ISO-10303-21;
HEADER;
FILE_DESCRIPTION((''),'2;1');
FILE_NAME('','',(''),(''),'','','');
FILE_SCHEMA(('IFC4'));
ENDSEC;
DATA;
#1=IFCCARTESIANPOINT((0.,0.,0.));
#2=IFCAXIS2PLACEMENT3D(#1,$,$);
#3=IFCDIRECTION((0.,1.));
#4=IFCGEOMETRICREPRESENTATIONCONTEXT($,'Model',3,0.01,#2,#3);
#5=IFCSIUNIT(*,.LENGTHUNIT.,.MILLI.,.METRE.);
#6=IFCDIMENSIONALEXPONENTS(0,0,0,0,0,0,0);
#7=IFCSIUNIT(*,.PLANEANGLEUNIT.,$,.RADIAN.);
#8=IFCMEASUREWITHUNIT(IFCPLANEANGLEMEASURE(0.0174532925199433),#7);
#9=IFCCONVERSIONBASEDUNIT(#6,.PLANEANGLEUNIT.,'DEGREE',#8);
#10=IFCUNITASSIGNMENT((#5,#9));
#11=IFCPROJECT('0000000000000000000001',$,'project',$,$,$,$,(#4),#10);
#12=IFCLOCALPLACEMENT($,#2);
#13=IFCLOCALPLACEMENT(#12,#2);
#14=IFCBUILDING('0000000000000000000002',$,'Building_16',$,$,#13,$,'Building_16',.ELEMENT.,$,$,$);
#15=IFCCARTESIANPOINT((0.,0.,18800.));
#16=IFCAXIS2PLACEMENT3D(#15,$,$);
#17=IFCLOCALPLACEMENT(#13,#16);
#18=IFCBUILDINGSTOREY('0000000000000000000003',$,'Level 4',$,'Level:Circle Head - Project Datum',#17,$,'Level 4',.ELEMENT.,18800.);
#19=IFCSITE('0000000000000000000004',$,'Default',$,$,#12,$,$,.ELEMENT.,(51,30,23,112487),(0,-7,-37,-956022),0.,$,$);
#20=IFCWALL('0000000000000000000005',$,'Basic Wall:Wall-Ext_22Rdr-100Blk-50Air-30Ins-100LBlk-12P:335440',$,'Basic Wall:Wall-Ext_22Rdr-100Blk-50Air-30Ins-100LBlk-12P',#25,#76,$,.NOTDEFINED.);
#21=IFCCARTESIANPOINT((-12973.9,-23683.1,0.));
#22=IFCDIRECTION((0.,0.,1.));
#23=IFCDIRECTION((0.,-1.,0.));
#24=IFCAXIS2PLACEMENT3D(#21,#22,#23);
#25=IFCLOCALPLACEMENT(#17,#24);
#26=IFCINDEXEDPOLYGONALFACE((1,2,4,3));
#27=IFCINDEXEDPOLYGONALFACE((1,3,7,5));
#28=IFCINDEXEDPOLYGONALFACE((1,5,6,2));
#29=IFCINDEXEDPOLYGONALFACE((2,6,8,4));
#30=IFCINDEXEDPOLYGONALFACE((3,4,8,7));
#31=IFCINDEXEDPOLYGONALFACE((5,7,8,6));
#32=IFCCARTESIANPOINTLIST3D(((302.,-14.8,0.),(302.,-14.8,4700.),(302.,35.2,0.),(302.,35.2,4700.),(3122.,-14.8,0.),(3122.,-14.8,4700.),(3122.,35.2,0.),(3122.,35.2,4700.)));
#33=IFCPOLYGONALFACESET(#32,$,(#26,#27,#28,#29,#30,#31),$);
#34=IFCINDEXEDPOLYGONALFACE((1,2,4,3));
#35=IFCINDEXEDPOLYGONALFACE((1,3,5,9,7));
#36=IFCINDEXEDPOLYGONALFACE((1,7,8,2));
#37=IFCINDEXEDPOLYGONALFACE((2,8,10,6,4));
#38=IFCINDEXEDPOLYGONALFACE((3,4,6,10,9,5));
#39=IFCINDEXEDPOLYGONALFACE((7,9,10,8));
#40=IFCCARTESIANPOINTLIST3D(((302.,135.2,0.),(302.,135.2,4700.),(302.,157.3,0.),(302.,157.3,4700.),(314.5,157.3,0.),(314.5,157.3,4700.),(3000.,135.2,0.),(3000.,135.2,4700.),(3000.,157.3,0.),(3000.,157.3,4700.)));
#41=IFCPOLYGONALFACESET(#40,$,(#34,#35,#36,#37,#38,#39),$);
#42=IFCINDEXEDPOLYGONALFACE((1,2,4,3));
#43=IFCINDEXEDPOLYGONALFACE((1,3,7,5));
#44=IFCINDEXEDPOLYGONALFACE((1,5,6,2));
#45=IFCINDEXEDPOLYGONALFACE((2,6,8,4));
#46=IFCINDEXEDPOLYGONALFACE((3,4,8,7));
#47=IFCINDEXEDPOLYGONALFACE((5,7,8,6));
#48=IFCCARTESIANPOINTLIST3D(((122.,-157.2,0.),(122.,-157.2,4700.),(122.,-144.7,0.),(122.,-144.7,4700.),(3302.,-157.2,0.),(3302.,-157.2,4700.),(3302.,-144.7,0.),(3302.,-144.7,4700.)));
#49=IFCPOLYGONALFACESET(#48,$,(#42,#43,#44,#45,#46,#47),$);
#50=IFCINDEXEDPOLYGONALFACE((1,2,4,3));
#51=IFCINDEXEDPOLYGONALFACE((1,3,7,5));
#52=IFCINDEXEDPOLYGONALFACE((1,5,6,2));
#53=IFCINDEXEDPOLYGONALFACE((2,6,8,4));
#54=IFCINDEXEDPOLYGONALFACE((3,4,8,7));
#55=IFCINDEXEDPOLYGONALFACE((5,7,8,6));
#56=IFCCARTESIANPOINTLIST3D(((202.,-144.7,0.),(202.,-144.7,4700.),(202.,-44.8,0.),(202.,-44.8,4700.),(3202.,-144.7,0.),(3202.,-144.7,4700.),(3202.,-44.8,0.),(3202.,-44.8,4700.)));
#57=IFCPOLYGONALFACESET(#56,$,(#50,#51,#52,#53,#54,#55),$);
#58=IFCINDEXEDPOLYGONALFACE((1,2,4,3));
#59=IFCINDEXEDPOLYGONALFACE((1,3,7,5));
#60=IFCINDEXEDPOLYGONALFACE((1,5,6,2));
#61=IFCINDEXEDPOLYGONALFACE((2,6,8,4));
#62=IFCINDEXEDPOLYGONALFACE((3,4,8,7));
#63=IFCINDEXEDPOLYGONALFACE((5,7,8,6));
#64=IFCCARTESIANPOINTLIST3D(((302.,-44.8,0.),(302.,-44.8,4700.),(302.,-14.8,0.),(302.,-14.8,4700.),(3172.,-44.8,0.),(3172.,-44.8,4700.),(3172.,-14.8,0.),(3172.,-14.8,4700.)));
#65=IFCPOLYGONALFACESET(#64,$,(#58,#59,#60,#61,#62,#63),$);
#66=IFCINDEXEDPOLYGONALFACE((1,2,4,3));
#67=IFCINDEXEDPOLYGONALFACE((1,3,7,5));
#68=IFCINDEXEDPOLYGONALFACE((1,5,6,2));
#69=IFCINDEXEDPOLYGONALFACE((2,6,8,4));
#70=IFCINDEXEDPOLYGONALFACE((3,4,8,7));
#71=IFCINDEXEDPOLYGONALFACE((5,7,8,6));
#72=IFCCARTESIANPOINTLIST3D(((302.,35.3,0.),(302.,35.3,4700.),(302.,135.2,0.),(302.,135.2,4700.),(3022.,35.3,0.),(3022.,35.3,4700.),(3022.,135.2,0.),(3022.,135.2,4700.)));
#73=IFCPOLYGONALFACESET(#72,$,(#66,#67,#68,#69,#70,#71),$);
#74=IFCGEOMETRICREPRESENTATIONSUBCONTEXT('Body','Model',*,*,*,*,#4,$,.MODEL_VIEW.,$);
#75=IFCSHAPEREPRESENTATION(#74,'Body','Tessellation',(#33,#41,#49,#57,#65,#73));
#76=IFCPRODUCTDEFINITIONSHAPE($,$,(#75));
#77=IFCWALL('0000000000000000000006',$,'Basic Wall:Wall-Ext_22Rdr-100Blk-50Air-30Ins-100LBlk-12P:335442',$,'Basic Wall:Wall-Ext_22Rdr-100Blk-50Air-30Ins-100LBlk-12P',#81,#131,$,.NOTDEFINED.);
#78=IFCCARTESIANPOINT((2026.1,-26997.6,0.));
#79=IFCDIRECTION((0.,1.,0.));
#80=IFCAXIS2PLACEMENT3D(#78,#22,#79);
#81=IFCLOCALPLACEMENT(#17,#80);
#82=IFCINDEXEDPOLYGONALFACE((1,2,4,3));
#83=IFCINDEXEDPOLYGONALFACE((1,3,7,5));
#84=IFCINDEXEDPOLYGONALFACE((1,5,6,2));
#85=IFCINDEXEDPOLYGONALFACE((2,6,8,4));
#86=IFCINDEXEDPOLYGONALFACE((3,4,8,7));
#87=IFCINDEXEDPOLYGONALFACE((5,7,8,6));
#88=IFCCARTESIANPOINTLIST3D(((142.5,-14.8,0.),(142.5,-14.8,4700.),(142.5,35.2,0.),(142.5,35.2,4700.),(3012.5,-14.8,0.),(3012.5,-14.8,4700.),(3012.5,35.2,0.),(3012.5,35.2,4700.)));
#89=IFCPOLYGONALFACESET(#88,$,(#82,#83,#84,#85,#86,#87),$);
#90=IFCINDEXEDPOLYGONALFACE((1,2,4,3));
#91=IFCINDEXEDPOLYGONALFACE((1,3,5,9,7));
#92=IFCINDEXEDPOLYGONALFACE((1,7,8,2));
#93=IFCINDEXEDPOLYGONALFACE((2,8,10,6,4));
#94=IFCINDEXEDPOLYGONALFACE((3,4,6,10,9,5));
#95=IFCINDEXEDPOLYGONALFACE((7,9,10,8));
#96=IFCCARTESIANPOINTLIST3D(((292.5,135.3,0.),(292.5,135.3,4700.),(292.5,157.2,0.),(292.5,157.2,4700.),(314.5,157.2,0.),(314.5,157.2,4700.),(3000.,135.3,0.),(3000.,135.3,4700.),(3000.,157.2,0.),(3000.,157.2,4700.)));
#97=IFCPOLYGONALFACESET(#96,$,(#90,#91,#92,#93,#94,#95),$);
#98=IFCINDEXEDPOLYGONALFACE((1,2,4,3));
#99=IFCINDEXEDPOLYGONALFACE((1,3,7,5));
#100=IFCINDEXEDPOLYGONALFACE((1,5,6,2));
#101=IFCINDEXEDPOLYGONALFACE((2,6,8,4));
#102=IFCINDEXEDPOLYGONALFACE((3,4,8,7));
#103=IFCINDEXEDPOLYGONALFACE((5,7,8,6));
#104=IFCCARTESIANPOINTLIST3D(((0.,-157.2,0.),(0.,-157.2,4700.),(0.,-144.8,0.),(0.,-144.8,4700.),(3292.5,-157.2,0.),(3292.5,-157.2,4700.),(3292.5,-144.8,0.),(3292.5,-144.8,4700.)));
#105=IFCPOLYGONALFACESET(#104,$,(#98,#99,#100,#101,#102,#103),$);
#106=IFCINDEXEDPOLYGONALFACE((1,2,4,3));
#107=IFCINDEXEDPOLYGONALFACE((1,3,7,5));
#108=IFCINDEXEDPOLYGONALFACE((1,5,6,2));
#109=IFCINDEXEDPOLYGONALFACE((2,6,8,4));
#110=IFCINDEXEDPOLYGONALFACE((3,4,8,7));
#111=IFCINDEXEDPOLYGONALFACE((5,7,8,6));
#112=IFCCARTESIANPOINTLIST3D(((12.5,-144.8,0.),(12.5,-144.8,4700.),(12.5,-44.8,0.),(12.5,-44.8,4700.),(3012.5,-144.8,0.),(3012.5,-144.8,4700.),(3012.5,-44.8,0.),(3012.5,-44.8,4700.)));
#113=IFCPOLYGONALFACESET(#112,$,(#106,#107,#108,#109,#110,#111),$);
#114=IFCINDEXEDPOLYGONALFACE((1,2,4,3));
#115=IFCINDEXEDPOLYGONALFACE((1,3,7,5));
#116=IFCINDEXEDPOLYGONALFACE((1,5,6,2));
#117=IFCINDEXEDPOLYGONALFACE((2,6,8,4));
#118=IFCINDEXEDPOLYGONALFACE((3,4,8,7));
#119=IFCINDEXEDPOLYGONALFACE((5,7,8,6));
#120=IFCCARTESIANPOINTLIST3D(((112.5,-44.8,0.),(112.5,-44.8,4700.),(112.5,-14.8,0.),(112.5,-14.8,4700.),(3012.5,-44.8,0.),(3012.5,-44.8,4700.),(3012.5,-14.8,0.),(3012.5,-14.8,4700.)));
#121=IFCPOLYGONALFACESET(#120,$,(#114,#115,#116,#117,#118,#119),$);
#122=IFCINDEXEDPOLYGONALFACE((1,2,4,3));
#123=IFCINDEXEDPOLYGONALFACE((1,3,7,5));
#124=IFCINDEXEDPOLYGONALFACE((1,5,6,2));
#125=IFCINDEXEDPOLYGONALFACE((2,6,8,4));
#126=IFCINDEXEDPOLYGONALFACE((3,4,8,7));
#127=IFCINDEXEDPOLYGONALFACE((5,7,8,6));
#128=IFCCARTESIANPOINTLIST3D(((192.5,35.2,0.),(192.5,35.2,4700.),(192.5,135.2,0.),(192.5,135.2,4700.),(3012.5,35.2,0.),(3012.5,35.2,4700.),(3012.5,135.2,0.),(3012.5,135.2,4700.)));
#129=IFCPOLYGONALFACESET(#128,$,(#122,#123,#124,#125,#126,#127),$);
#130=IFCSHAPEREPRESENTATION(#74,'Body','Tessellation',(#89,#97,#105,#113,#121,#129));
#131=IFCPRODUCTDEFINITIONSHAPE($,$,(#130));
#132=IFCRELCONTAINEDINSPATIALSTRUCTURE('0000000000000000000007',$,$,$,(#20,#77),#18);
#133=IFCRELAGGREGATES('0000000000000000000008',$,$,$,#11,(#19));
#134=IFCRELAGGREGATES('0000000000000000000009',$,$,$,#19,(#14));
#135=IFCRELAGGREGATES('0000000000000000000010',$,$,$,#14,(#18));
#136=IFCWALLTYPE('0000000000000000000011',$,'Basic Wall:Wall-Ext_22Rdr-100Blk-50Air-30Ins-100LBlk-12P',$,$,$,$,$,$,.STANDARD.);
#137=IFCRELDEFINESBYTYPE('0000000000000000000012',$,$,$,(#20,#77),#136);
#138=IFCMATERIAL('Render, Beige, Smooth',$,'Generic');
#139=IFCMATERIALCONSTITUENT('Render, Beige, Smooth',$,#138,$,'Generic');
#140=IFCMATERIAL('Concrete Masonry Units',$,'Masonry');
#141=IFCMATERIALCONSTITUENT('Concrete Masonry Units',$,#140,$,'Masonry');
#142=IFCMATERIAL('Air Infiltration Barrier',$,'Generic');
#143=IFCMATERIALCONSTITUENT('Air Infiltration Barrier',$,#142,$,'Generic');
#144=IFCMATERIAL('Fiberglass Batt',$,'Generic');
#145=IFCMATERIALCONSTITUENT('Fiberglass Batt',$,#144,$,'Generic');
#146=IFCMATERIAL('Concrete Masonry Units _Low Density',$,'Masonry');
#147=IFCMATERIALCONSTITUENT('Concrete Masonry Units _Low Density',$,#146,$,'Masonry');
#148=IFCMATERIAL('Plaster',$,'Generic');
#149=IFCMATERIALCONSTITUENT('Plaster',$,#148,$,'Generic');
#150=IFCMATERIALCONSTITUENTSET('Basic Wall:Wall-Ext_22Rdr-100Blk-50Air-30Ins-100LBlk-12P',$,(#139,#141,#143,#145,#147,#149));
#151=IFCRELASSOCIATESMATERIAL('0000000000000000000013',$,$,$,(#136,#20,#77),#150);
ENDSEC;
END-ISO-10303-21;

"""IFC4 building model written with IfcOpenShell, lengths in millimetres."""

from ifc_helpers import new_model, entity, si_unit, converted_unit, direction, frame, origin, place, context, subcontext, project, spatial, indexed_curve, outline, extrude, material, constituent, constituent_set, type_object, element, save


model = new_model("IFC4")

# Units and contexts
model_context = context("Model", 3, precision=0.01, world=origin(), true_north=direction((0.0, 1.0)))
body_context = subcontext(model_context, "Body", "Model", "MODEL_VIEW")
ifc_project = project(units=[si_unit("LENGTHUNIT", "METRE", prefix="MILLI"), converted_unit("PLANEANGLEUNIT", "DEGREE", entity("IfcPlaneAngleMeasure", 0.0174532925199433), si_unit("PLANEANGLEUNIT", "RADIAN"), dimensions=[0, 0, 0, 0, 0, 0, 0])], contexts=[model_context])

# Site, building, storey
site_placement = place(None, origin())
site = spatial("IfcSite", under=ifc_project, at=site_placement, Name="Default", CompositionType="ELEMENT", RefLatitude=(51, 30, 23, 112487), RefLongitude=(0, -7, -37, -956022), RefElevation=0.0)
building_placement = place(site_placement, origin())
building = spatial("IfcBuilding", under=site, at=building_placement, Name="Building_16", LongName="Building_16", CompositionType="ELEMENT")
storey_placement = place(building_placement, frame((0.0, 0.0, 18800.0)))
storey = spatial("IfcBuildingStorey", under=building, at=storey_placement, Name="Level 4", ObjectType="Level:Circle Head - Project Datum", LongName="Level 4", CompositionType="ELEMENT", Elevation=18800.0)

# Shared definitions
ifc_material_1 = material(Name="Render, Beige, Smooth", Category="Generic")
ifc_constituent_1 = constituent(ifc_material_1, Name="Render, Beige, Smooth", Category="Generic")
ifc_material_2 = material(Name="Concrete Masonry Units", Category="Masonry")
ifc_constituent_2 = constituent(ifc_material_2, Name="Concrete Masonry Units", Category="Masonry")
ifc_material_3 = material(Name="Air Infiltration Barrier", Category="Generic")
ifc_constituent_3 = constituent(ifc_material_3, Name="Air Infiltration Barrier", Category="Generic")
ifc_material_4 = material(Name="Fiberglass Batt", Category="Generic")
ifc_constituent_4 = constituent(ifc_material_4, Name="Fiberglass Batt", Category="Generic")
ifc_material_5 = material(Name="Concrete Masonry Units _Low Density", Category="Masonry")
ifc_constituent_5 = constituent(ifc_material_5, Name="Concrete Masonry Units _Low Density", Category="Masonry")
ifc_material_6 = material(Name="Plaster", Category="Generic")
ifc_constituent_6 = constituent(ifc_material_6, Name="Plaster", Category="Generic")
ifc_constituent_set_1 = constituent_set(constituents=[ifc_constituent_1, ifc_constituent_2, ifc_constituent_3, ifc_constituent_4, ifc_constituent_5, ifc_constituent_6], Name="Basic Wall:Wall-Ext_22Rdr-100Blk-50Air-30Ins-100LBlk-12P")
wall_type_1 = type_object("IfcWallType", Name="Basic Wall:Wall-Ext_22Rdr-100Blk-50Air-30Ins-100LBlk-12P", PredefinedType="STANDARD", material=ifc_constituent_set_1)

# Wall
wall_1_placement = place(storey_placement, frame((-12973.9, -23683.1, 0.0), z_axis=(0.0, 0.0, 1.0), x_axis=(0.0, -1.0, 0.0)))
element("IfcWall", 1, at=wall_1_placement, inside=storey, type_object=wall_type_1, material=ifc_constituent_set_1, Name="Basic Wall:Wall-Ext_22Rdr-100Blk-50Air-30Ins-100LBlk-12P:335440", ObjectType="Basic Wall:Wall-Ext_22Rdr-100Blk-50Air-30Ins-100LBlk-12P", PredefinedType="NOTDEFINED", context=body_context, shape_type="SweptSolid", body=[
    extrude(outline(indexed_curve([(-1410.0, -25.0), (1410.0, -25.0), (1410.0, 25.0), (-1410.0, 25.0), (-1410.0, -25.0)], self_intersect=False)), frame((1712.0, 10.2, 0.0)), (0.0, 0.0, 1.0), 4700.0),
    extrude(outline(indexed_curve([(1069.2, -8.8), (1081.7, -8.8), (1081.7, 13.2), (-1616.3, 13.2), (-1616.3, -8.8), (1069.2, -8.8)], self_intersect=False)), frame((1383.7, 148.5, 0.0), z_axis=(0.0, 0.0, 1.0), x_axis=(-1.0, 0.0, 0.0)), (0.0, 0.0, 1.0), 4700.0),
    extrude(outline(indexed_curve([(-6.2, -1590.0), (6.3, -1590.0), (6.3, 1590.0), (-6.2, 1590.0), (-6.2, -1590.0)], self_intersect=False)), frame((1712.0, -151.0, 0.0), z_axis=(0.0, 0.0, 1.0), x_axis=(0.0, 1.0, 0.0)), (0.0, 0.0, 1.0), 4700.0),
    extrude(outline(indexed_curve([(-1500.0, -50.0), (1500.0, -50.0), (1500.0, 50.0), (-1500.0, 50.0), (-1500.0, -50.0)], self_intersect=False)), frame((1702.0, -94.8, 0.0)), (0.0, 0.0, 1.0), 4700.0),
    extrude(outline(indexed_curve([(-1435.0, -15.0), (1435.0, -15.0), (1435.0, 15.0), (-1435.0, 15.0), (-1435.0, -15.0)], self_intersect=False)), frame((1737.0, -29.7, 0.0)), (0.0, 0.0, 1.0), 4700.0),
    extrude(outline(indexed_curve([(-1360.0, -50.0), (1360.0, -50.0), (1360.0, 50.0), (-1360.0, 50.0), (-1360.0, -50.0)], self_intersect=False)), frame((1662.0, 85.3, 0.0)), (0.0, 0.0, 1.0), 4700.0),
])

# Wall
wall_2_placement = place(storey_placement, frame((2026.1, -26997.6, 0.0), z_axis=(0.0, 0.0, 1.0), x_axis=(0.0, 1.0, 0.0)))
element("IfcWall", 2, at=wall_2_placement, inside=storey, type_object=wall_type_1, material=ifc_constituent_set_1, Name="Basic Wall:Wall-Ext_22Rdr-100Blk-50Air-30Ins-100LBlk-12P:335442", ObjectType="Basic Wall:Wall-Ext_22Rdr-100Blk-50Air-30Ins-100LBlk-12P", PredefinedType="NOTDEFINED", context=body_context, shape_type="SweptSolid", body=[
    extrude(outline(indexed_curve([(-1435.0, -25.0), (1435.0, -25.0), (1435.0, 25.0), (-1435.0, 25.0), (-1435.0, -25.0)], self_intersect=False)), frame((1577.5, 10.3, 0.0)), (0.0, 0.0, 1.0), 4700.0),
    extrude(outline(indexed_curve([(1065.4, -8.8), (1087.4, -8.8), (1087.4, 13.2), (-1620.1, 13.2), (-1620.1, -8.8), (1065.4, -8.8)], self_intersect=False)), frame((1379.9, 148.4, 0.0), z_axis=(0.0, 0.0, 1.0), x_axis=(-1.0, 0.0, 0.0)), (0.0, 0.0, 1.0), 4700.0),
    extrude(outline(indexed_curve([(-6.2, -1646.2), (6.2, -1646.2), (6.2, 1646.2), (-6.2, 1646.2), (-6.2, -1646.2)], self_intersect=False)), frame((1646.2, -151.0, 0.0), z_axis=(0.0, 0.0, 1.0), x_axis=(0.0, 1.0, 0.0)), (0.0, 0.0, 1.0), 4700.0),
    extrude(outline(indexed_curve([(-1500.0, -50.0), (1500.0, -50.0), (1500.0, 50.0), (-1500.0, 50.0), (-1500.0, -50.0)], self_intersect=False)), frame((1512.5, -94.8, 0.0)), (0.0, 0.0, 1.0), 4700.0),
    extrude(outline(indexed_curve([(-1450.0, -15.0), (1450.0, -15.0), (1450.0, 15.0), (-1450.0, 15.0), (-1450.0, -15.0)], self_intersect=False)), frame((1562.5, -29.8, 0.0)), (0.0, 0.0, 1.0), 4700.0),
    extrude(outline(indexed_curve([(-1410.0, -50.0), (1410.0, -50.0), (1410.0, 50.0), (-1410.0, 50.0), (-1410.0, -50.0)], self_intersect=False)), frame((1602.5, 85.3, 0.0)), (0.0, 0.0, 1.0), 4700.0),
])

save(model, "model.ifc")
